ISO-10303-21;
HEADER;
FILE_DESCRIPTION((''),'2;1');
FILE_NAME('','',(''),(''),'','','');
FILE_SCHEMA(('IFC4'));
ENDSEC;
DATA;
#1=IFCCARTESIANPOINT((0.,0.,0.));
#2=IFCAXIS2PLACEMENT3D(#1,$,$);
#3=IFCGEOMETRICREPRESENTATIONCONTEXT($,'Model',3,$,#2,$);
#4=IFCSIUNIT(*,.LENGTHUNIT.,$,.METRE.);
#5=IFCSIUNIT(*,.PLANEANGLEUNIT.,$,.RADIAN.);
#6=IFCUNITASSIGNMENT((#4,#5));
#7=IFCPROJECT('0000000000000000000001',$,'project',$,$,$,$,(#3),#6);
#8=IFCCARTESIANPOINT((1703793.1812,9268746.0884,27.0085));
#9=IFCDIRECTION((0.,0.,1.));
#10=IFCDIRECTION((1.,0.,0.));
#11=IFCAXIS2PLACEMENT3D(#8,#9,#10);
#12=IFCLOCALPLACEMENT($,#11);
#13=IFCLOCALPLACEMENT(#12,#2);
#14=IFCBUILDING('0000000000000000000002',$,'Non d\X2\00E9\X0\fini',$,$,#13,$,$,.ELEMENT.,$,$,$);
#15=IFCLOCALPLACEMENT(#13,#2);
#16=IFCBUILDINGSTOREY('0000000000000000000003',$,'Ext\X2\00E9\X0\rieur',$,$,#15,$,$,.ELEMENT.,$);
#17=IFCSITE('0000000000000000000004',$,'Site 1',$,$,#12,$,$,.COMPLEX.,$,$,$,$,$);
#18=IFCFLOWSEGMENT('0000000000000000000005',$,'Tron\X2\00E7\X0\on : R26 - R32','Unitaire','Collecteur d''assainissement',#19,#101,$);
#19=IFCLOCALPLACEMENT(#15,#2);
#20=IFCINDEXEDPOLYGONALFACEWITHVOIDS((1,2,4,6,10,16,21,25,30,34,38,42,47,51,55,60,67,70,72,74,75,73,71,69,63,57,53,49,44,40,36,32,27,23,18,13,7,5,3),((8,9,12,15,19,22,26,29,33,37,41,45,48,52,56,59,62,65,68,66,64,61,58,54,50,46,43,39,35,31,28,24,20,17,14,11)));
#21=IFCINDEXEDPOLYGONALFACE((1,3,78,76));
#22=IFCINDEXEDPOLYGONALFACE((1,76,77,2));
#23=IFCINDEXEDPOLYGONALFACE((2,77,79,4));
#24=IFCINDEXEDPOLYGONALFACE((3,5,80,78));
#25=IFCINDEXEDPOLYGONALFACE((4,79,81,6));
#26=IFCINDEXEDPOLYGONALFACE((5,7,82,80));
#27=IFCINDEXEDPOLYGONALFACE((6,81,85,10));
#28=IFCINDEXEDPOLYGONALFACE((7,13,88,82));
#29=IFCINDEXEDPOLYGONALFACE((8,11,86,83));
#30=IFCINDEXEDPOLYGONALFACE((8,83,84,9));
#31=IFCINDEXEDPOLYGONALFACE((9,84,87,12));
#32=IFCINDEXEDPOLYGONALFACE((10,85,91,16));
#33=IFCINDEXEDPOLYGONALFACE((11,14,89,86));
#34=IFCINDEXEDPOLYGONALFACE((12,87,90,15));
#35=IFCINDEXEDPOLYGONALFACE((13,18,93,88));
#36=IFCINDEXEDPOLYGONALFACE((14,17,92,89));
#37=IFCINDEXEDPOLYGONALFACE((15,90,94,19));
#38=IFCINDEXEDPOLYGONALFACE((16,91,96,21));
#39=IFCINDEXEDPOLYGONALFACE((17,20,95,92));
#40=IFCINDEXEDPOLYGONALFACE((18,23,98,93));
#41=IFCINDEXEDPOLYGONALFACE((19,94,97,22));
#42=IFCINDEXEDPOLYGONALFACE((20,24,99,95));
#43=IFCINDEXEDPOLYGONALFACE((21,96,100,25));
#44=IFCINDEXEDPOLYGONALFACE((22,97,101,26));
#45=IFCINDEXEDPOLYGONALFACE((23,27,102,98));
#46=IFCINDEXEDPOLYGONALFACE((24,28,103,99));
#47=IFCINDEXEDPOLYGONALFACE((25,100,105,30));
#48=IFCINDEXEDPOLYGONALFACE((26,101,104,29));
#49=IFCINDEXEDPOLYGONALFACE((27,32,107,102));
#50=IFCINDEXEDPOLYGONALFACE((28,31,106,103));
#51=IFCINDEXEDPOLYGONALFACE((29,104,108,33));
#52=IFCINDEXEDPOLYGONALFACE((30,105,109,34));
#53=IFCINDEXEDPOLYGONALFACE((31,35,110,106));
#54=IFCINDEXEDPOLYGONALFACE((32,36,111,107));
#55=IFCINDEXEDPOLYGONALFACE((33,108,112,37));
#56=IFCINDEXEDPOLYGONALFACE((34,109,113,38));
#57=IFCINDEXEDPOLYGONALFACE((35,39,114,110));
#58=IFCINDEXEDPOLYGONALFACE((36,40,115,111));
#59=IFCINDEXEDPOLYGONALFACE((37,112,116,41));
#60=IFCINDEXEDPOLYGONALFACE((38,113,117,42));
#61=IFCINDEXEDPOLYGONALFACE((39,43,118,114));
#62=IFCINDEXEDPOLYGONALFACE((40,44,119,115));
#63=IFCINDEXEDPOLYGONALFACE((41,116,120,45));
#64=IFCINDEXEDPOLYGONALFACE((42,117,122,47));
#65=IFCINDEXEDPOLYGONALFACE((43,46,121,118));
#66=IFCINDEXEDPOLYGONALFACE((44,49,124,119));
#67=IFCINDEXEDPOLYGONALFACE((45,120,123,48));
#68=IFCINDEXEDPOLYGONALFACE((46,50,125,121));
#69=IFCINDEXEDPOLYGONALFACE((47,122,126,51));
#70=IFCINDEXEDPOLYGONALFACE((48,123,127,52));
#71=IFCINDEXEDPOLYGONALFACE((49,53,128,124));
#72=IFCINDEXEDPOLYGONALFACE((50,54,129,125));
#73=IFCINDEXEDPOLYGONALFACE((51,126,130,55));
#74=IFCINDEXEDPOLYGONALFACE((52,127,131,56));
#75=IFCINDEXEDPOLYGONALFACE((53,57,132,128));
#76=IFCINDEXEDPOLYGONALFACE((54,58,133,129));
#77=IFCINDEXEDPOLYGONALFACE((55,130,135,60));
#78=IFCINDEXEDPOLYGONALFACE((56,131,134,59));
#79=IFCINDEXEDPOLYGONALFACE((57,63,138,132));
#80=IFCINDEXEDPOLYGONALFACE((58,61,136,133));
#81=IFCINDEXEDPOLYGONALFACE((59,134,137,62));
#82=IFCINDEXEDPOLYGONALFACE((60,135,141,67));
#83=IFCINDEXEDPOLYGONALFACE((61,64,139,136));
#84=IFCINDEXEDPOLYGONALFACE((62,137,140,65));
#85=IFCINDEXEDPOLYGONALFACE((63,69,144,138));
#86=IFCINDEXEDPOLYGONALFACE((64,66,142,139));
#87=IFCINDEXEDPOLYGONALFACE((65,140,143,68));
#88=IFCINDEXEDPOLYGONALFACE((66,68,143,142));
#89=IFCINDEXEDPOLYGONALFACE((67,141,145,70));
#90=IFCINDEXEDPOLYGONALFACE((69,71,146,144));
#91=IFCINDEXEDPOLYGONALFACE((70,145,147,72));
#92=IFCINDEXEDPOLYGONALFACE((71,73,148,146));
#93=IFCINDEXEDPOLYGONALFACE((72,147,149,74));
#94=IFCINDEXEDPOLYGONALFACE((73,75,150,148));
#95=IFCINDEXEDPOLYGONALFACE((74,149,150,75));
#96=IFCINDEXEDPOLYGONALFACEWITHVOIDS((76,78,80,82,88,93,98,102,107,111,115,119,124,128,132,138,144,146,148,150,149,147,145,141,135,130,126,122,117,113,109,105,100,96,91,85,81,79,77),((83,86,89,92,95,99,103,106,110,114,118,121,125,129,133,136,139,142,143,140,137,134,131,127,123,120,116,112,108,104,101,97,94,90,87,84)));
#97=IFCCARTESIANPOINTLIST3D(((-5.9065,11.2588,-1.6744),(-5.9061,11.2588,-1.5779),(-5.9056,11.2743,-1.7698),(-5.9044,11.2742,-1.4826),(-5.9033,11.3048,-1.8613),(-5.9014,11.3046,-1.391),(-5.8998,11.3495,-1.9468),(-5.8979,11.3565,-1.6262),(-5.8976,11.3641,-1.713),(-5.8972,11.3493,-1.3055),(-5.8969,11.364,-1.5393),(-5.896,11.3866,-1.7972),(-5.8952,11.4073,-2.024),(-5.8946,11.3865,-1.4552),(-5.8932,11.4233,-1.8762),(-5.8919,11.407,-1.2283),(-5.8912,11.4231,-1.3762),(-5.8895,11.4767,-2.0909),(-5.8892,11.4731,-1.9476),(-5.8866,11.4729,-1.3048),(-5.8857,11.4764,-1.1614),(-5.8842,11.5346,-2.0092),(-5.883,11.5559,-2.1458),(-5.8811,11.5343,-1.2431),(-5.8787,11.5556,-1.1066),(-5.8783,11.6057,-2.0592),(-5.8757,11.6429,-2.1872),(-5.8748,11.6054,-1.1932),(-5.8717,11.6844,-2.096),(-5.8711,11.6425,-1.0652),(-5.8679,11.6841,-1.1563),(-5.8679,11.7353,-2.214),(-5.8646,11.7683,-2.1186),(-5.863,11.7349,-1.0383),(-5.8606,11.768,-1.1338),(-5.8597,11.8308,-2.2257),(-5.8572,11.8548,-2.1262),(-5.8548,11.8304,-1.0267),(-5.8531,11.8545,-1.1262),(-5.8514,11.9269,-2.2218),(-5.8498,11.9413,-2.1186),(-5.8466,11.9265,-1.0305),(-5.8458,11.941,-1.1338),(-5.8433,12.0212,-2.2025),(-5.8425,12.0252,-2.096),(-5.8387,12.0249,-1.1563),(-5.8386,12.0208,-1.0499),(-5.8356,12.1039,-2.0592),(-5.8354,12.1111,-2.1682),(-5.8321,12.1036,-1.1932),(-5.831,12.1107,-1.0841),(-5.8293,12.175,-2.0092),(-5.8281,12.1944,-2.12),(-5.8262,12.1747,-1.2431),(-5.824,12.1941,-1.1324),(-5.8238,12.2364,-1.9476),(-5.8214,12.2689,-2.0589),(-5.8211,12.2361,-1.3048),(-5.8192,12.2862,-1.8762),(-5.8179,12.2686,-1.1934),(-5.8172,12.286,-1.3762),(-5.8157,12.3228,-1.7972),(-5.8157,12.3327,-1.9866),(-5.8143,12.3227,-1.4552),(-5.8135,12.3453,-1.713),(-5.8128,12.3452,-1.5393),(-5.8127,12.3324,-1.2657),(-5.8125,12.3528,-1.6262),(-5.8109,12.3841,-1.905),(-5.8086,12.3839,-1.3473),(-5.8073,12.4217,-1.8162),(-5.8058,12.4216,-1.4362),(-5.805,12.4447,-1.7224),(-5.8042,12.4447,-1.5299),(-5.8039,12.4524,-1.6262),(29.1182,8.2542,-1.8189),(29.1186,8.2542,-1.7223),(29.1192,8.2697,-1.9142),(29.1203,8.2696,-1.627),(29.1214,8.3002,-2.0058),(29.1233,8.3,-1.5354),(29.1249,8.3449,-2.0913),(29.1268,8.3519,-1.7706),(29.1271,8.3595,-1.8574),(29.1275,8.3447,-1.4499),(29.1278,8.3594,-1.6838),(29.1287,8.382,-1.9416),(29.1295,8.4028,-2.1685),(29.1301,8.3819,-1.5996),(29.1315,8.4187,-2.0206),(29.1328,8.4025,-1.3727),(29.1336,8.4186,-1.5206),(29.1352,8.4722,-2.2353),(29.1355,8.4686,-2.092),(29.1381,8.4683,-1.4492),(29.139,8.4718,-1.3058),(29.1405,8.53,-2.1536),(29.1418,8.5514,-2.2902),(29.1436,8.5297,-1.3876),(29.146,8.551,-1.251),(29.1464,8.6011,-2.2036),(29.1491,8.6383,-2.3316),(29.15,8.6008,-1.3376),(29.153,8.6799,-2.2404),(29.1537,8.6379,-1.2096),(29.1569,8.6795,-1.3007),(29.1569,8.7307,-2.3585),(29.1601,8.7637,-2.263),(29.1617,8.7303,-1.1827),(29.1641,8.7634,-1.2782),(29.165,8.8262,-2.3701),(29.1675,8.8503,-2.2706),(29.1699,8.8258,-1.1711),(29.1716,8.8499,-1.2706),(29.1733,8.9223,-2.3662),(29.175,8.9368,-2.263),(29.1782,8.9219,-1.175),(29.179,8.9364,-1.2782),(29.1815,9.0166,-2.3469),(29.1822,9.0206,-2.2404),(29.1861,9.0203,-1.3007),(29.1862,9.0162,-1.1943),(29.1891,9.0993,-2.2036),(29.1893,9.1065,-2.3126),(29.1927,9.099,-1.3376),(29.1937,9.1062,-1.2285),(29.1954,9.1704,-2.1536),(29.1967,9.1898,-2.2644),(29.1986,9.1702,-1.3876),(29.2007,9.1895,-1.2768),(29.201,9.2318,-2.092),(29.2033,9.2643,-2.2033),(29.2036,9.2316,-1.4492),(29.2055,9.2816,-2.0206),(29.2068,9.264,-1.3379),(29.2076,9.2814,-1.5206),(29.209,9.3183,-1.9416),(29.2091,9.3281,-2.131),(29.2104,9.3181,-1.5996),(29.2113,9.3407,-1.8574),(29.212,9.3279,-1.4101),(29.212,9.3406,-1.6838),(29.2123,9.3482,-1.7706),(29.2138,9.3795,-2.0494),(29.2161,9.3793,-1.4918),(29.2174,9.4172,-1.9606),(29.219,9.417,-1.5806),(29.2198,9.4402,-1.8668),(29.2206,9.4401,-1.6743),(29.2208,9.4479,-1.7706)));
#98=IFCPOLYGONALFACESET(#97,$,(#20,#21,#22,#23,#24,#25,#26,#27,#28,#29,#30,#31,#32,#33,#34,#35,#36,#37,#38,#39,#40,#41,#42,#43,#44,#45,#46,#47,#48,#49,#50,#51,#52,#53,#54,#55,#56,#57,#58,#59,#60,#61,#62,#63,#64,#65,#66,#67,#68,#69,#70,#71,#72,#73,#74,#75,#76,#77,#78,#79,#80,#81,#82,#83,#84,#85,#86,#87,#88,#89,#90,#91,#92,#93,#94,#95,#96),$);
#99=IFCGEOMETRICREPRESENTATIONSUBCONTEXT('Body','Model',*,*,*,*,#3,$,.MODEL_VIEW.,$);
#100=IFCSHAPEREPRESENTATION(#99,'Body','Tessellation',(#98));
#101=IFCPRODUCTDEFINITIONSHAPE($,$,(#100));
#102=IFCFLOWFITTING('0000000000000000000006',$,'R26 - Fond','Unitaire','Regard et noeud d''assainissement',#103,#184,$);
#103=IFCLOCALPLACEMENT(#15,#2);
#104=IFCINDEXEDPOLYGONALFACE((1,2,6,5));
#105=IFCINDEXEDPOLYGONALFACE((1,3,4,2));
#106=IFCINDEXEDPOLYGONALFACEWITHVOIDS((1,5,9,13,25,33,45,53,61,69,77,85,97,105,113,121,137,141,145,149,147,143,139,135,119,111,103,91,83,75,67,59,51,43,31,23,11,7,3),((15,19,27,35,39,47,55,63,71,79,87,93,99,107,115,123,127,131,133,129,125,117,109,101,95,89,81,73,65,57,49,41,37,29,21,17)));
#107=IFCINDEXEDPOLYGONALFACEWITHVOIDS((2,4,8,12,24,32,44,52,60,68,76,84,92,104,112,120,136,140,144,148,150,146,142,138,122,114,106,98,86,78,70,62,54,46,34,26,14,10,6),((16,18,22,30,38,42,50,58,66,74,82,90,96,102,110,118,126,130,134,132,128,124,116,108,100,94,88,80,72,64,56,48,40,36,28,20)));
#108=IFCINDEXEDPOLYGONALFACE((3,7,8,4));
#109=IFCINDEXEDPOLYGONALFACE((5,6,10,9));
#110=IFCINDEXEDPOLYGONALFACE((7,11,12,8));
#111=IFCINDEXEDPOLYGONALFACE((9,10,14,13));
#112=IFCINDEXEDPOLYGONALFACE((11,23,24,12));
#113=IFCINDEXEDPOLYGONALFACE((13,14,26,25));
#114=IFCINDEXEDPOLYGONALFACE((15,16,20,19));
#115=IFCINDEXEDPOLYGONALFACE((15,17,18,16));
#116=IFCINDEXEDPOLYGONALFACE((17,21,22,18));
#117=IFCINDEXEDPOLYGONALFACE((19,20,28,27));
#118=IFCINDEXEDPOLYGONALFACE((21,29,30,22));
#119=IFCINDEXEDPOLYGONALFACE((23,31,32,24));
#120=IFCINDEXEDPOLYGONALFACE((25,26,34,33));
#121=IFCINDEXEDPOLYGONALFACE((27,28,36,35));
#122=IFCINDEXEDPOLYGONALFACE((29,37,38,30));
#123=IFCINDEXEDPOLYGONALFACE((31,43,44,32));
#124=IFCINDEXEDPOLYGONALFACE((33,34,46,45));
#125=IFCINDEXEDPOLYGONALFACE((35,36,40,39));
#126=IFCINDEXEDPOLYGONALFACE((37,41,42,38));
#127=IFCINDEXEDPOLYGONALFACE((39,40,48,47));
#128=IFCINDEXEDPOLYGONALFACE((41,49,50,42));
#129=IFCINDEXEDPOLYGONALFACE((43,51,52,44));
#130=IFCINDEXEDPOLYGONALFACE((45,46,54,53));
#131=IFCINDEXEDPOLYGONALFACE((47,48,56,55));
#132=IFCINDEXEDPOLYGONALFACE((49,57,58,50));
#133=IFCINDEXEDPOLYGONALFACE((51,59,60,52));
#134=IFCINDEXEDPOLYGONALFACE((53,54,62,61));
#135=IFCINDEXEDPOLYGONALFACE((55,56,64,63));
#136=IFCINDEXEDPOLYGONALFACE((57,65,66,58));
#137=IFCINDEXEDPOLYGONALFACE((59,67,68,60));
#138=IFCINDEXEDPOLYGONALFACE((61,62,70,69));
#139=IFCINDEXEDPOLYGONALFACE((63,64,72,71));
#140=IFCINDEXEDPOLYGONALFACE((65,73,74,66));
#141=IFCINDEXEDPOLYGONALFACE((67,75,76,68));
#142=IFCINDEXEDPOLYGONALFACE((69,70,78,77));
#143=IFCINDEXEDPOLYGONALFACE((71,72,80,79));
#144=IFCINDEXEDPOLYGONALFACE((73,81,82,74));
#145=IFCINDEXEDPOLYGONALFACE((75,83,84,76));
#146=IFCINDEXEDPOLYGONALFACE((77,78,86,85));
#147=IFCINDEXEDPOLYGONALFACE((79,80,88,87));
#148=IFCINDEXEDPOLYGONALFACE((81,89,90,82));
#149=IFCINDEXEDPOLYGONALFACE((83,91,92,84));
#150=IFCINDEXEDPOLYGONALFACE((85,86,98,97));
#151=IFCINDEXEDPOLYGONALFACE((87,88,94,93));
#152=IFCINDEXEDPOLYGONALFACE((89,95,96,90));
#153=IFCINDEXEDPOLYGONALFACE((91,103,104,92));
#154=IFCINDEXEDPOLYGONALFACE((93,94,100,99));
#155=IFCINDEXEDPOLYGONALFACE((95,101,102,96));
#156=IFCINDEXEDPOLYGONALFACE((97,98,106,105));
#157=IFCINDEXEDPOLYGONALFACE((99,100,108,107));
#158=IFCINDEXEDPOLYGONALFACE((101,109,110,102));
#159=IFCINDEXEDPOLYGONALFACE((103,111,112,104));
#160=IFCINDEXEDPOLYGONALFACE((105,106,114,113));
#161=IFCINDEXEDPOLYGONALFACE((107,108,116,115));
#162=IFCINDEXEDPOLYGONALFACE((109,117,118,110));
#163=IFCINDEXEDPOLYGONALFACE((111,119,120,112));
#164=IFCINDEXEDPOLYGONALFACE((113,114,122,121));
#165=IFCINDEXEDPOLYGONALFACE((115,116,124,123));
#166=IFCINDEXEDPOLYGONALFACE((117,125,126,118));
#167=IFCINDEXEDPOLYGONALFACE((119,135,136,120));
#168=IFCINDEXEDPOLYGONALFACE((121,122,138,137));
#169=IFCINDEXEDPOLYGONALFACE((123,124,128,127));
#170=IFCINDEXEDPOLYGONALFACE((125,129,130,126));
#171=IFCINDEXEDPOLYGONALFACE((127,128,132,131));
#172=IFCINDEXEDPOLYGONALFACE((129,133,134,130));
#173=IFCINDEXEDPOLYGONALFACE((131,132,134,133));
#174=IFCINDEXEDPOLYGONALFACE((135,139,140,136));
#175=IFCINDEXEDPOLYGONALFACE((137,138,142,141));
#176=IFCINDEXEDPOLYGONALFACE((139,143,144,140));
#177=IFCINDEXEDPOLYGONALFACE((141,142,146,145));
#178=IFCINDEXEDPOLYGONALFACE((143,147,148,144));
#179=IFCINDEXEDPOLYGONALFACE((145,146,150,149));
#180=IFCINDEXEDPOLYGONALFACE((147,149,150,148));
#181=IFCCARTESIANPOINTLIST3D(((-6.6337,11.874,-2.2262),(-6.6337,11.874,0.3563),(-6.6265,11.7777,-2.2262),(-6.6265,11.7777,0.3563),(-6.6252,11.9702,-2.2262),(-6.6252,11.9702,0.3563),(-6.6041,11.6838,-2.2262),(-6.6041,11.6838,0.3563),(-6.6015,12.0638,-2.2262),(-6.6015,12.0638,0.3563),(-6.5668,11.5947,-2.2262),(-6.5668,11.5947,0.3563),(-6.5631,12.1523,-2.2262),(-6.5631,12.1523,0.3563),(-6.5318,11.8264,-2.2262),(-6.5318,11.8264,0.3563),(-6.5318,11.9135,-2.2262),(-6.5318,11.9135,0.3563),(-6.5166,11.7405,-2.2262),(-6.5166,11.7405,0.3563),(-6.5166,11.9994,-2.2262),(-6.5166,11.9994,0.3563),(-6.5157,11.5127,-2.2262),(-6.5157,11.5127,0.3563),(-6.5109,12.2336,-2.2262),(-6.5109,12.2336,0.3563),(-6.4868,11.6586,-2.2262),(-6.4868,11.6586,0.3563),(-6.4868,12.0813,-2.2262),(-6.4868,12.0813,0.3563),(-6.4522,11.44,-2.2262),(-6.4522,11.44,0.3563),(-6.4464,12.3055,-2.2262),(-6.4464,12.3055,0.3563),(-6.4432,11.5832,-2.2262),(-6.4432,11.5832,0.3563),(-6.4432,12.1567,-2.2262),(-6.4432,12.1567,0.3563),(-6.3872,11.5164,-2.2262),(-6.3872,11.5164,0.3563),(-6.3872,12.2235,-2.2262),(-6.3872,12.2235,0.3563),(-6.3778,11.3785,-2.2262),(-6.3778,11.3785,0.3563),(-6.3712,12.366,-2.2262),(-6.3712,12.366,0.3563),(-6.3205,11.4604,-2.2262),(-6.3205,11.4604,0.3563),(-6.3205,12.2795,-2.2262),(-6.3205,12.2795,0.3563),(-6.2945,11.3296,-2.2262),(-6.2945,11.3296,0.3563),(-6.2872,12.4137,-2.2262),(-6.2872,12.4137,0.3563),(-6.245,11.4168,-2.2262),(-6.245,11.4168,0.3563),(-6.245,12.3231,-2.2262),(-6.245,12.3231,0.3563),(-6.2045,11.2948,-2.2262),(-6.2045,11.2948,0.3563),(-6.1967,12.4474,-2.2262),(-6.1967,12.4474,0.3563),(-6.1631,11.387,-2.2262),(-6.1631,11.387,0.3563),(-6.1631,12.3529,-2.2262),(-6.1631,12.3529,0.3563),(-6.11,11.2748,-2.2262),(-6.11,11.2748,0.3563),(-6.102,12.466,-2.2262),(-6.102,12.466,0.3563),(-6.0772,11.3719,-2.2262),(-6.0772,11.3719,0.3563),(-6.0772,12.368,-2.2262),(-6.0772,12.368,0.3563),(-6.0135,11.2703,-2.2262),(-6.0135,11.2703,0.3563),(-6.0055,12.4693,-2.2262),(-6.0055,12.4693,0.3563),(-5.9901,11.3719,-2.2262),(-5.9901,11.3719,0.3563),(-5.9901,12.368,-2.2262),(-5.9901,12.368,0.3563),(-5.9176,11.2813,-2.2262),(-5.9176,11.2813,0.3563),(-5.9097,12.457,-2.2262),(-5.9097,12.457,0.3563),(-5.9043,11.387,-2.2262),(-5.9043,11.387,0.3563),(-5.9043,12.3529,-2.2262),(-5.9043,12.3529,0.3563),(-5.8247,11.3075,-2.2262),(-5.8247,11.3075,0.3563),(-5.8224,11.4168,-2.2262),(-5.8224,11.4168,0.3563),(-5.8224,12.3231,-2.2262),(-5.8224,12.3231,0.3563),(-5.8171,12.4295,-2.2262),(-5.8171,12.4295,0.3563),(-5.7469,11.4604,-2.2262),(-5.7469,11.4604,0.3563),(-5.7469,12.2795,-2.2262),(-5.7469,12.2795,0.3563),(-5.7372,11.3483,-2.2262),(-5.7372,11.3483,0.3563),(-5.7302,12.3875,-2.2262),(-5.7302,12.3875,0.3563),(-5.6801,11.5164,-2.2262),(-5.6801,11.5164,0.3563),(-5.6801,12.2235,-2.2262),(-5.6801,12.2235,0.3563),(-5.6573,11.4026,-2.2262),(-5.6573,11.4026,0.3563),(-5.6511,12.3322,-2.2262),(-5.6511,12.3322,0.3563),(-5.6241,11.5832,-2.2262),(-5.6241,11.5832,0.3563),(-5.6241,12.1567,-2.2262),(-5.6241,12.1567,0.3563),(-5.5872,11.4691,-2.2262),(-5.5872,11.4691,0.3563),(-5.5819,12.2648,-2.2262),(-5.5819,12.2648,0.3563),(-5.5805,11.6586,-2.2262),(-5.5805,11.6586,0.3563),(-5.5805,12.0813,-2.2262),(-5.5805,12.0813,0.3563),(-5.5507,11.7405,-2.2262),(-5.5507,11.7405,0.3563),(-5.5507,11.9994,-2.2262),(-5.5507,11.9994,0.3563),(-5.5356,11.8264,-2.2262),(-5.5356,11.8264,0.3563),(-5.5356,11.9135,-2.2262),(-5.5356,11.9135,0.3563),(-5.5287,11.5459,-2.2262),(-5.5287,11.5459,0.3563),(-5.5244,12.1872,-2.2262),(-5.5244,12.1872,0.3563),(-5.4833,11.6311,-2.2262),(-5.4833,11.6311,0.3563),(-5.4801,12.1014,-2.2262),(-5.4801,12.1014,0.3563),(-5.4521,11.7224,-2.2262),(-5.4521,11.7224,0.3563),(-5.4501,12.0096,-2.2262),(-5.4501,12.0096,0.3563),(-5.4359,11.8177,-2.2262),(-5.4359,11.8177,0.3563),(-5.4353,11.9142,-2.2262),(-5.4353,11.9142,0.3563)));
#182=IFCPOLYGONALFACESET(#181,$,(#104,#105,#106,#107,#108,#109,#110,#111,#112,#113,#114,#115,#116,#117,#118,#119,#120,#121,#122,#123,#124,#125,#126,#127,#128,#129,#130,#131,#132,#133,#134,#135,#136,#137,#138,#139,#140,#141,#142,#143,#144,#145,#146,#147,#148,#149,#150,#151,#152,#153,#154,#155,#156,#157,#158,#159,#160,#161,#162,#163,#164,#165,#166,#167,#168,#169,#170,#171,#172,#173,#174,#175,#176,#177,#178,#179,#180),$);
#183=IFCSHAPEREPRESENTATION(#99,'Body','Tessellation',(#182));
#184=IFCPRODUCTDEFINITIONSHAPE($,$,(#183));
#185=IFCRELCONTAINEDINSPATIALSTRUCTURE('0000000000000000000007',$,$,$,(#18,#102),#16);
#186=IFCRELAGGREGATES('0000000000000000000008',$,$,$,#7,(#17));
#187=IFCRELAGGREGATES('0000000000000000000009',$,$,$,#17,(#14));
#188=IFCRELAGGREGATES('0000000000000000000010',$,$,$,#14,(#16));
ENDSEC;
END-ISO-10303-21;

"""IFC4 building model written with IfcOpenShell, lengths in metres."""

from ifc_helpers import new_model, si_unit, frame, origin, origin_2d, place, context, subcontext, project, spatial, hollow_circle, extrude, element, save


model = new_model("IFC4")

# Units and contexts
model_context = context("Model", 3, world=origin())
body_context = subcontext(model_context, "Body", "Model", "MODEL_VIEW")
ifc_project = project(units=[si_unit("LENGTHUNIT", "METRE"), si_unit("PLANEANGLEUNIT", "RADIAN")], contexts=[model_context])

# Site, building, storey
site_placement = place(None, frame((1703793.1812, 9268746.0884, 27.0085), z_axis=(0.0, 0.0, 1.0), x_axis=(1.0, 0.0, 0.0)))
site = spatial("IfcSite", under=ifc_project, at=site_placement, Name="Site 1", CompositionType="COMPLEX")
building_placement = place(site_placement, origin())
building = spatial("IfcBuilding", under=site, at=building_placement, Name="Non défini", CompositionType="ELEMENT")
storey_placement = place(building_placement, origin())
storey = spatial("IfcBuildingStorey", under=building, at=storey_placement, Name="Extérieur", CompositionType="ELEMENT")

# Flow segment
flow_segment_1_placement = place(storey_placement, origin())
element("IfcFlowSegment", 1, at=flow_segment_1_placement, inside=storey, Name="Tronçon : R26 - R32", Description="Unitaire", ObjectType="Collecteur d'assainissement", context=body_context, shape_type="SweptSolid", body=[
    extrude(hollow_circle(Radius=0.6, WallThickness=0.1, at=origin_2d()), frame((-5.8552, 11.8546, -1.6262), z_axis=(0.996332, -0.085469, -0.004108), x_axis=(0.08547, 0.996341, 0.0)), (0.0, 0.0, 1.0), 35.1537),
])

# Flow fitting
flow_fitting_1_placement = place(storey_placement, origin())
element("IfcFlowFitting", 2, at=flow_fitting_1_placement, inside=storey, Name="R26 - Fond", Description="Unitaire", ObjectType="Regard et noeud d'assainissement", context=body_context, shape_type="SweptSolid", body=[
    extrude(hollow_circle(Radius=0.6, WallThickness=0.1, at=origin_2d()), frame((-6.0337, 11.8699, -2.2262), z_axis=(0.0, 0.0, 1.0), x_axis=(0.996194, -0.087159, 0.0)), (0.0, 0.0, 1.0), 2.5825),
])

save(model, "model.ifc")
